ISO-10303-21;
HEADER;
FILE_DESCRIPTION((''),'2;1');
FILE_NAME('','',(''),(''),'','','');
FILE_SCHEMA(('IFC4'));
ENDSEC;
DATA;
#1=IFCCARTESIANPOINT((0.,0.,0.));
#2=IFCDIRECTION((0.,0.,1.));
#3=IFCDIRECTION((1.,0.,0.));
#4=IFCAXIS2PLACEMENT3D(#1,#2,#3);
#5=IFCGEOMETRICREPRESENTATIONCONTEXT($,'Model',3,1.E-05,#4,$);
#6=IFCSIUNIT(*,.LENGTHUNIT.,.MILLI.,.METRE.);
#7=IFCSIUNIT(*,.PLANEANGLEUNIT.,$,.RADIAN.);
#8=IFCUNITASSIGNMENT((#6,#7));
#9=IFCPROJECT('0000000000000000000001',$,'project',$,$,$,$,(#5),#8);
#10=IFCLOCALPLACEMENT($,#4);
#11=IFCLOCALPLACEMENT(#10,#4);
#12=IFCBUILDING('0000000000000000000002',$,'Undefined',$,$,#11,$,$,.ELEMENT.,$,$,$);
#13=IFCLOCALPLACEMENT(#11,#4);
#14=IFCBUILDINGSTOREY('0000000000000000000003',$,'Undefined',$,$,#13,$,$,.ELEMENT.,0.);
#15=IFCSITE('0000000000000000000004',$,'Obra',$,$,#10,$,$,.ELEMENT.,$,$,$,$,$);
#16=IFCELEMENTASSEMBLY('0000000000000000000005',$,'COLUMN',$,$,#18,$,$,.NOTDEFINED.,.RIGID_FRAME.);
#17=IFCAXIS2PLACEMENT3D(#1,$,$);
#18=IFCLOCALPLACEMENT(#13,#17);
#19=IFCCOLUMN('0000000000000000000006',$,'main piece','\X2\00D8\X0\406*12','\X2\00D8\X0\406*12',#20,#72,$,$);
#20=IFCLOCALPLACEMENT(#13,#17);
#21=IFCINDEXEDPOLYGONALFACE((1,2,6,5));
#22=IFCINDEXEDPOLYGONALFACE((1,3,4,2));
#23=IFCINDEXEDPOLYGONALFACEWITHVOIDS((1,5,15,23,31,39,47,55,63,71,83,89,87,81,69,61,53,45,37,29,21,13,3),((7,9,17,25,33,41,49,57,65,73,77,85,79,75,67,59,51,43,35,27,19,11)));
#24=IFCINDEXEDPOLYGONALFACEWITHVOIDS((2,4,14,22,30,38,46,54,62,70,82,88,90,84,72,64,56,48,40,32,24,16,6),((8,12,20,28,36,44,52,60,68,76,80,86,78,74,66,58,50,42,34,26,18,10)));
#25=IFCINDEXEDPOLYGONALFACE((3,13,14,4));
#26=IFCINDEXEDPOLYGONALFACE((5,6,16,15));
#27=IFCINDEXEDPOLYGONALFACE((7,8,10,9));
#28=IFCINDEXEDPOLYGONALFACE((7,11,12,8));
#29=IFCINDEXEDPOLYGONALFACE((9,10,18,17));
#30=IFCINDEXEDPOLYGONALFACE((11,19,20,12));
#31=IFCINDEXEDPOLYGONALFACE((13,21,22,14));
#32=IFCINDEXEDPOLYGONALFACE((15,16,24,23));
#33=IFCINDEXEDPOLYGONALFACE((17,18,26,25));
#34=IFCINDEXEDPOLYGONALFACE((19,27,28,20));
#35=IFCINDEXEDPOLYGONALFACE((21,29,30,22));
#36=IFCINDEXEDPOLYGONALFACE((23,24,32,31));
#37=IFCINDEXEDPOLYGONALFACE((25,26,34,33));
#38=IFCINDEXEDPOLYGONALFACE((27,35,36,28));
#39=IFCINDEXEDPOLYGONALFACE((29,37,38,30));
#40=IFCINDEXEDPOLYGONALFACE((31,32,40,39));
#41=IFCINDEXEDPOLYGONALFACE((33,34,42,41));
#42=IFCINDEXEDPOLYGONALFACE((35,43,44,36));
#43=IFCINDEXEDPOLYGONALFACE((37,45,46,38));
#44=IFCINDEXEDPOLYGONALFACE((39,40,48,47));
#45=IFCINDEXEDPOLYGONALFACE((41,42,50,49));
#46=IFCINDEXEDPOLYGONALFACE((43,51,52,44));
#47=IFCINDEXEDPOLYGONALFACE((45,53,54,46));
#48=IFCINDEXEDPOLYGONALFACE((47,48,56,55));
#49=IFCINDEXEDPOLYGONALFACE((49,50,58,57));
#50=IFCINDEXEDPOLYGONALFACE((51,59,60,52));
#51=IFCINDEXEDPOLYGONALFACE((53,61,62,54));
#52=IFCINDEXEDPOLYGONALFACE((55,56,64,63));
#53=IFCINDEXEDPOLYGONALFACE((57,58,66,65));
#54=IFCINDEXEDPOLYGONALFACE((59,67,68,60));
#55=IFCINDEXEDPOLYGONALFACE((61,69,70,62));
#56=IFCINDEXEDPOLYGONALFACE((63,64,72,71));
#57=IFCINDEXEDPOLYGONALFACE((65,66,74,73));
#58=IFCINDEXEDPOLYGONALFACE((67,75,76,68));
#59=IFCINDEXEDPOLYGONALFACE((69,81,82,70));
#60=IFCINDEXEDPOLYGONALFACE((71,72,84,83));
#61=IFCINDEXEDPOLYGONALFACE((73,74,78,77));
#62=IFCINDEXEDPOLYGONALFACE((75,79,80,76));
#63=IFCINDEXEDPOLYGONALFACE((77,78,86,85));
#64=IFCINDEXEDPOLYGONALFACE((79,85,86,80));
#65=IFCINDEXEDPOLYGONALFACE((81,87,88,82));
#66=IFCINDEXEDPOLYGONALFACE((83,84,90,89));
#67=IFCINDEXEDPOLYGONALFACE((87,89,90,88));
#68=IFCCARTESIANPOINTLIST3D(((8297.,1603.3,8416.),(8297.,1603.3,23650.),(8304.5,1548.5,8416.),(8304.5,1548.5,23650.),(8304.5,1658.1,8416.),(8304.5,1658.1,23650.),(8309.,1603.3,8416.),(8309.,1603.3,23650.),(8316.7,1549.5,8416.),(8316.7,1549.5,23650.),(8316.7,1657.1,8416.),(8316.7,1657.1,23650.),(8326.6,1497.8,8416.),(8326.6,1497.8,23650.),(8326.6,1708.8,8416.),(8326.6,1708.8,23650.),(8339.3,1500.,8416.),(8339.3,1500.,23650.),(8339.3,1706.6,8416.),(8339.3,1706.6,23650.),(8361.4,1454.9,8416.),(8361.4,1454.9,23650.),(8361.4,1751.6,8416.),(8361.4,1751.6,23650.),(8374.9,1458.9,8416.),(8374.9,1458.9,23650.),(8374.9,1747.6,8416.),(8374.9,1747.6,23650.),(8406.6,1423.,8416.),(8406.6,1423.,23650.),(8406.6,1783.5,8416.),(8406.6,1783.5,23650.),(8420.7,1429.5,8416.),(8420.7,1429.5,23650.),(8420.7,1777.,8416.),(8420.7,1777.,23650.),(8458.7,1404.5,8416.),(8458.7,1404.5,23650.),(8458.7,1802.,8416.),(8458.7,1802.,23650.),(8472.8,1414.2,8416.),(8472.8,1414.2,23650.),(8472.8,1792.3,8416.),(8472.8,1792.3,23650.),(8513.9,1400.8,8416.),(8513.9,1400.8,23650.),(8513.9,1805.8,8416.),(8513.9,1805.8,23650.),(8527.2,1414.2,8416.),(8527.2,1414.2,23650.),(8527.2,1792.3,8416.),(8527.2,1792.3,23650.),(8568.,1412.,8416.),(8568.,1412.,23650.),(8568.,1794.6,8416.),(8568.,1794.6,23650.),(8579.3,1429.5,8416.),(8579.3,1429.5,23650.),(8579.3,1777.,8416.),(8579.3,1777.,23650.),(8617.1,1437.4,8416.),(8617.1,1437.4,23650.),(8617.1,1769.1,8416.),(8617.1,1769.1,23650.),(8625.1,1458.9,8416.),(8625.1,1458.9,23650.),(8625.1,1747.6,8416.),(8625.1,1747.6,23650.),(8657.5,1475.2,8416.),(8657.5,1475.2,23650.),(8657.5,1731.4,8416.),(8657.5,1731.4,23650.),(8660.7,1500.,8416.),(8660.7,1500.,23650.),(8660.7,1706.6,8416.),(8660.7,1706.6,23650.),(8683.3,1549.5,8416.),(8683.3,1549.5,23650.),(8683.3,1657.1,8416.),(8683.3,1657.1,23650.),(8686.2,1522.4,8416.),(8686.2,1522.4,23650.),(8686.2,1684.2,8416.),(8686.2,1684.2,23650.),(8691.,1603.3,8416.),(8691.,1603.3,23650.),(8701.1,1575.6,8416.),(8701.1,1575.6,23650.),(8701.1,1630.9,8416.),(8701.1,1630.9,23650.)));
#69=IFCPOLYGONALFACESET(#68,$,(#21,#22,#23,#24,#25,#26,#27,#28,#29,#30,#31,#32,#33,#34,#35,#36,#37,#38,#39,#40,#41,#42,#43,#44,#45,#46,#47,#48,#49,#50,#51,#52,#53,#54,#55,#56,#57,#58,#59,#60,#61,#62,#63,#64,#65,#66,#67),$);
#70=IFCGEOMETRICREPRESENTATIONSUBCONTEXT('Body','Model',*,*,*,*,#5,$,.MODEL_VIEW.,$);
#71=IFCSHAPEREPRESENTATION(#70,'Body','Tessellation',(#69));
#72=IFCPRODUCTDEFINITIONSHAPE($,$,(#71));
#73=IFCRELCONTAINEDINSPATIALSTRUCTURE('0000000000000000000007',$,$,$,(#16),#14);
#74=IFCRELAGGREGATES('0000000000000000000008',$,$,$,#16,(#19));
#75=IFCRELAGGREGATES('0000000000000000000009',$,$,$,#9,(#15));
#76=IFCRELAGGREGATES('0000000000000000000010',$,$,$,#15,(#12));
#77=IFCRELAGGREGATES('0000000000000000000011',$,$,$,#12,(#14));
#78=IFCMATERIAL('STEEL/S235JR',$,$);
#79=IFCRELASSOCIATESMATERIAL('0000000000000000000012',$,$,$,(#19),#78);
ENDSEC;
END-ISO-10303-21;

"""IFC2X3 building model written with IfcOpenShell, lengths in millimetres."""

from ifc_helpers import new_model, si_unit, frame, origin_with_axes, origin_2d_with_axis, place, context, subcontext, project, spatial, hollow_circle, extrude, clip, halfspace, material, element, aggregate, save


model = new_model("IFC2X3")

# Units and contexts
model_context = context("Model", 3, precision=1e-05, world=origin_with_axes())
body_context = subcontext(model_context, "Body", "Model", "MODEL_VIEW")
ifc_project = project(units=[si_unit("LENGTHUNIT", "METRE", prefix="MILLI"), si_unit("PLANEANGLEUNIT", "RADIAN")], contexts=[model_context])

# Site, building, storey
site_placement = place(None, origin_with_axes())
site = spatial("IfcSite", under=ifc_project, at=site_placement, Name="Obra", CompositionType="ELEMENT")
building_placement = place(site_placement, origin_with_axes())
building = spatial("IfcBuilding", under=site, at=building_placement, Name="Undefined", CompositionType="ELEMENT")
storey_placement = place(building_placement, origin_with_axes())
storey = spatial("IfcBuildingStorey", under=building, at=storey_placement, Name="Undefined", CompositionType="ELEMENT", Elevation=0.0)

# Element assembly, column
assembly_1_placement = place(storey_placement, origin_with_axes())
assembly_1 = element("IfcElementAssembly", 1, at=assembly_1_placement, inside=storey, Name="COLUMN", AssemblyPlace="NOTDEFINED", PredefinedType="RIGID_FRAME")
ifc_material_1 = material(Name="STEEL/S235JR")
column_placement = place(assembly_1_placement, frame((8500.0, 1603.3, 8400.0), z_axis=(0.0, 0.0, 1.0), x_axis=(0.0, 1.0, 0.0)))
column = element("IfcColumn", 2, at=column_placement, material=ifc_material_1, Name="main piece", Description="Ø406*12", ObjectType="Ø406*12", context=body_context, shape_type="Clipping", body=[
    clip(extrude(hollow_circle(Radius=203.0, WallThickness=12.0, at=origin_2d_with_axis()), frame((0.0, 0.0, 15250.0), z_axis=(0.0, 0.0, -1.0), x_axis=(0.0, 1.0, 0.0)), (0.0, 0.0, 1.0), 15234.0), halfspace(frame((-203.0, 0.0, 16.0), z_axis=(0.0, 0.0, 1.0), x_axis=(0.0, 1.0, 0.0)), True)),
])

aggregate(assembly_1, [column])

save(model, "model.ifc")
